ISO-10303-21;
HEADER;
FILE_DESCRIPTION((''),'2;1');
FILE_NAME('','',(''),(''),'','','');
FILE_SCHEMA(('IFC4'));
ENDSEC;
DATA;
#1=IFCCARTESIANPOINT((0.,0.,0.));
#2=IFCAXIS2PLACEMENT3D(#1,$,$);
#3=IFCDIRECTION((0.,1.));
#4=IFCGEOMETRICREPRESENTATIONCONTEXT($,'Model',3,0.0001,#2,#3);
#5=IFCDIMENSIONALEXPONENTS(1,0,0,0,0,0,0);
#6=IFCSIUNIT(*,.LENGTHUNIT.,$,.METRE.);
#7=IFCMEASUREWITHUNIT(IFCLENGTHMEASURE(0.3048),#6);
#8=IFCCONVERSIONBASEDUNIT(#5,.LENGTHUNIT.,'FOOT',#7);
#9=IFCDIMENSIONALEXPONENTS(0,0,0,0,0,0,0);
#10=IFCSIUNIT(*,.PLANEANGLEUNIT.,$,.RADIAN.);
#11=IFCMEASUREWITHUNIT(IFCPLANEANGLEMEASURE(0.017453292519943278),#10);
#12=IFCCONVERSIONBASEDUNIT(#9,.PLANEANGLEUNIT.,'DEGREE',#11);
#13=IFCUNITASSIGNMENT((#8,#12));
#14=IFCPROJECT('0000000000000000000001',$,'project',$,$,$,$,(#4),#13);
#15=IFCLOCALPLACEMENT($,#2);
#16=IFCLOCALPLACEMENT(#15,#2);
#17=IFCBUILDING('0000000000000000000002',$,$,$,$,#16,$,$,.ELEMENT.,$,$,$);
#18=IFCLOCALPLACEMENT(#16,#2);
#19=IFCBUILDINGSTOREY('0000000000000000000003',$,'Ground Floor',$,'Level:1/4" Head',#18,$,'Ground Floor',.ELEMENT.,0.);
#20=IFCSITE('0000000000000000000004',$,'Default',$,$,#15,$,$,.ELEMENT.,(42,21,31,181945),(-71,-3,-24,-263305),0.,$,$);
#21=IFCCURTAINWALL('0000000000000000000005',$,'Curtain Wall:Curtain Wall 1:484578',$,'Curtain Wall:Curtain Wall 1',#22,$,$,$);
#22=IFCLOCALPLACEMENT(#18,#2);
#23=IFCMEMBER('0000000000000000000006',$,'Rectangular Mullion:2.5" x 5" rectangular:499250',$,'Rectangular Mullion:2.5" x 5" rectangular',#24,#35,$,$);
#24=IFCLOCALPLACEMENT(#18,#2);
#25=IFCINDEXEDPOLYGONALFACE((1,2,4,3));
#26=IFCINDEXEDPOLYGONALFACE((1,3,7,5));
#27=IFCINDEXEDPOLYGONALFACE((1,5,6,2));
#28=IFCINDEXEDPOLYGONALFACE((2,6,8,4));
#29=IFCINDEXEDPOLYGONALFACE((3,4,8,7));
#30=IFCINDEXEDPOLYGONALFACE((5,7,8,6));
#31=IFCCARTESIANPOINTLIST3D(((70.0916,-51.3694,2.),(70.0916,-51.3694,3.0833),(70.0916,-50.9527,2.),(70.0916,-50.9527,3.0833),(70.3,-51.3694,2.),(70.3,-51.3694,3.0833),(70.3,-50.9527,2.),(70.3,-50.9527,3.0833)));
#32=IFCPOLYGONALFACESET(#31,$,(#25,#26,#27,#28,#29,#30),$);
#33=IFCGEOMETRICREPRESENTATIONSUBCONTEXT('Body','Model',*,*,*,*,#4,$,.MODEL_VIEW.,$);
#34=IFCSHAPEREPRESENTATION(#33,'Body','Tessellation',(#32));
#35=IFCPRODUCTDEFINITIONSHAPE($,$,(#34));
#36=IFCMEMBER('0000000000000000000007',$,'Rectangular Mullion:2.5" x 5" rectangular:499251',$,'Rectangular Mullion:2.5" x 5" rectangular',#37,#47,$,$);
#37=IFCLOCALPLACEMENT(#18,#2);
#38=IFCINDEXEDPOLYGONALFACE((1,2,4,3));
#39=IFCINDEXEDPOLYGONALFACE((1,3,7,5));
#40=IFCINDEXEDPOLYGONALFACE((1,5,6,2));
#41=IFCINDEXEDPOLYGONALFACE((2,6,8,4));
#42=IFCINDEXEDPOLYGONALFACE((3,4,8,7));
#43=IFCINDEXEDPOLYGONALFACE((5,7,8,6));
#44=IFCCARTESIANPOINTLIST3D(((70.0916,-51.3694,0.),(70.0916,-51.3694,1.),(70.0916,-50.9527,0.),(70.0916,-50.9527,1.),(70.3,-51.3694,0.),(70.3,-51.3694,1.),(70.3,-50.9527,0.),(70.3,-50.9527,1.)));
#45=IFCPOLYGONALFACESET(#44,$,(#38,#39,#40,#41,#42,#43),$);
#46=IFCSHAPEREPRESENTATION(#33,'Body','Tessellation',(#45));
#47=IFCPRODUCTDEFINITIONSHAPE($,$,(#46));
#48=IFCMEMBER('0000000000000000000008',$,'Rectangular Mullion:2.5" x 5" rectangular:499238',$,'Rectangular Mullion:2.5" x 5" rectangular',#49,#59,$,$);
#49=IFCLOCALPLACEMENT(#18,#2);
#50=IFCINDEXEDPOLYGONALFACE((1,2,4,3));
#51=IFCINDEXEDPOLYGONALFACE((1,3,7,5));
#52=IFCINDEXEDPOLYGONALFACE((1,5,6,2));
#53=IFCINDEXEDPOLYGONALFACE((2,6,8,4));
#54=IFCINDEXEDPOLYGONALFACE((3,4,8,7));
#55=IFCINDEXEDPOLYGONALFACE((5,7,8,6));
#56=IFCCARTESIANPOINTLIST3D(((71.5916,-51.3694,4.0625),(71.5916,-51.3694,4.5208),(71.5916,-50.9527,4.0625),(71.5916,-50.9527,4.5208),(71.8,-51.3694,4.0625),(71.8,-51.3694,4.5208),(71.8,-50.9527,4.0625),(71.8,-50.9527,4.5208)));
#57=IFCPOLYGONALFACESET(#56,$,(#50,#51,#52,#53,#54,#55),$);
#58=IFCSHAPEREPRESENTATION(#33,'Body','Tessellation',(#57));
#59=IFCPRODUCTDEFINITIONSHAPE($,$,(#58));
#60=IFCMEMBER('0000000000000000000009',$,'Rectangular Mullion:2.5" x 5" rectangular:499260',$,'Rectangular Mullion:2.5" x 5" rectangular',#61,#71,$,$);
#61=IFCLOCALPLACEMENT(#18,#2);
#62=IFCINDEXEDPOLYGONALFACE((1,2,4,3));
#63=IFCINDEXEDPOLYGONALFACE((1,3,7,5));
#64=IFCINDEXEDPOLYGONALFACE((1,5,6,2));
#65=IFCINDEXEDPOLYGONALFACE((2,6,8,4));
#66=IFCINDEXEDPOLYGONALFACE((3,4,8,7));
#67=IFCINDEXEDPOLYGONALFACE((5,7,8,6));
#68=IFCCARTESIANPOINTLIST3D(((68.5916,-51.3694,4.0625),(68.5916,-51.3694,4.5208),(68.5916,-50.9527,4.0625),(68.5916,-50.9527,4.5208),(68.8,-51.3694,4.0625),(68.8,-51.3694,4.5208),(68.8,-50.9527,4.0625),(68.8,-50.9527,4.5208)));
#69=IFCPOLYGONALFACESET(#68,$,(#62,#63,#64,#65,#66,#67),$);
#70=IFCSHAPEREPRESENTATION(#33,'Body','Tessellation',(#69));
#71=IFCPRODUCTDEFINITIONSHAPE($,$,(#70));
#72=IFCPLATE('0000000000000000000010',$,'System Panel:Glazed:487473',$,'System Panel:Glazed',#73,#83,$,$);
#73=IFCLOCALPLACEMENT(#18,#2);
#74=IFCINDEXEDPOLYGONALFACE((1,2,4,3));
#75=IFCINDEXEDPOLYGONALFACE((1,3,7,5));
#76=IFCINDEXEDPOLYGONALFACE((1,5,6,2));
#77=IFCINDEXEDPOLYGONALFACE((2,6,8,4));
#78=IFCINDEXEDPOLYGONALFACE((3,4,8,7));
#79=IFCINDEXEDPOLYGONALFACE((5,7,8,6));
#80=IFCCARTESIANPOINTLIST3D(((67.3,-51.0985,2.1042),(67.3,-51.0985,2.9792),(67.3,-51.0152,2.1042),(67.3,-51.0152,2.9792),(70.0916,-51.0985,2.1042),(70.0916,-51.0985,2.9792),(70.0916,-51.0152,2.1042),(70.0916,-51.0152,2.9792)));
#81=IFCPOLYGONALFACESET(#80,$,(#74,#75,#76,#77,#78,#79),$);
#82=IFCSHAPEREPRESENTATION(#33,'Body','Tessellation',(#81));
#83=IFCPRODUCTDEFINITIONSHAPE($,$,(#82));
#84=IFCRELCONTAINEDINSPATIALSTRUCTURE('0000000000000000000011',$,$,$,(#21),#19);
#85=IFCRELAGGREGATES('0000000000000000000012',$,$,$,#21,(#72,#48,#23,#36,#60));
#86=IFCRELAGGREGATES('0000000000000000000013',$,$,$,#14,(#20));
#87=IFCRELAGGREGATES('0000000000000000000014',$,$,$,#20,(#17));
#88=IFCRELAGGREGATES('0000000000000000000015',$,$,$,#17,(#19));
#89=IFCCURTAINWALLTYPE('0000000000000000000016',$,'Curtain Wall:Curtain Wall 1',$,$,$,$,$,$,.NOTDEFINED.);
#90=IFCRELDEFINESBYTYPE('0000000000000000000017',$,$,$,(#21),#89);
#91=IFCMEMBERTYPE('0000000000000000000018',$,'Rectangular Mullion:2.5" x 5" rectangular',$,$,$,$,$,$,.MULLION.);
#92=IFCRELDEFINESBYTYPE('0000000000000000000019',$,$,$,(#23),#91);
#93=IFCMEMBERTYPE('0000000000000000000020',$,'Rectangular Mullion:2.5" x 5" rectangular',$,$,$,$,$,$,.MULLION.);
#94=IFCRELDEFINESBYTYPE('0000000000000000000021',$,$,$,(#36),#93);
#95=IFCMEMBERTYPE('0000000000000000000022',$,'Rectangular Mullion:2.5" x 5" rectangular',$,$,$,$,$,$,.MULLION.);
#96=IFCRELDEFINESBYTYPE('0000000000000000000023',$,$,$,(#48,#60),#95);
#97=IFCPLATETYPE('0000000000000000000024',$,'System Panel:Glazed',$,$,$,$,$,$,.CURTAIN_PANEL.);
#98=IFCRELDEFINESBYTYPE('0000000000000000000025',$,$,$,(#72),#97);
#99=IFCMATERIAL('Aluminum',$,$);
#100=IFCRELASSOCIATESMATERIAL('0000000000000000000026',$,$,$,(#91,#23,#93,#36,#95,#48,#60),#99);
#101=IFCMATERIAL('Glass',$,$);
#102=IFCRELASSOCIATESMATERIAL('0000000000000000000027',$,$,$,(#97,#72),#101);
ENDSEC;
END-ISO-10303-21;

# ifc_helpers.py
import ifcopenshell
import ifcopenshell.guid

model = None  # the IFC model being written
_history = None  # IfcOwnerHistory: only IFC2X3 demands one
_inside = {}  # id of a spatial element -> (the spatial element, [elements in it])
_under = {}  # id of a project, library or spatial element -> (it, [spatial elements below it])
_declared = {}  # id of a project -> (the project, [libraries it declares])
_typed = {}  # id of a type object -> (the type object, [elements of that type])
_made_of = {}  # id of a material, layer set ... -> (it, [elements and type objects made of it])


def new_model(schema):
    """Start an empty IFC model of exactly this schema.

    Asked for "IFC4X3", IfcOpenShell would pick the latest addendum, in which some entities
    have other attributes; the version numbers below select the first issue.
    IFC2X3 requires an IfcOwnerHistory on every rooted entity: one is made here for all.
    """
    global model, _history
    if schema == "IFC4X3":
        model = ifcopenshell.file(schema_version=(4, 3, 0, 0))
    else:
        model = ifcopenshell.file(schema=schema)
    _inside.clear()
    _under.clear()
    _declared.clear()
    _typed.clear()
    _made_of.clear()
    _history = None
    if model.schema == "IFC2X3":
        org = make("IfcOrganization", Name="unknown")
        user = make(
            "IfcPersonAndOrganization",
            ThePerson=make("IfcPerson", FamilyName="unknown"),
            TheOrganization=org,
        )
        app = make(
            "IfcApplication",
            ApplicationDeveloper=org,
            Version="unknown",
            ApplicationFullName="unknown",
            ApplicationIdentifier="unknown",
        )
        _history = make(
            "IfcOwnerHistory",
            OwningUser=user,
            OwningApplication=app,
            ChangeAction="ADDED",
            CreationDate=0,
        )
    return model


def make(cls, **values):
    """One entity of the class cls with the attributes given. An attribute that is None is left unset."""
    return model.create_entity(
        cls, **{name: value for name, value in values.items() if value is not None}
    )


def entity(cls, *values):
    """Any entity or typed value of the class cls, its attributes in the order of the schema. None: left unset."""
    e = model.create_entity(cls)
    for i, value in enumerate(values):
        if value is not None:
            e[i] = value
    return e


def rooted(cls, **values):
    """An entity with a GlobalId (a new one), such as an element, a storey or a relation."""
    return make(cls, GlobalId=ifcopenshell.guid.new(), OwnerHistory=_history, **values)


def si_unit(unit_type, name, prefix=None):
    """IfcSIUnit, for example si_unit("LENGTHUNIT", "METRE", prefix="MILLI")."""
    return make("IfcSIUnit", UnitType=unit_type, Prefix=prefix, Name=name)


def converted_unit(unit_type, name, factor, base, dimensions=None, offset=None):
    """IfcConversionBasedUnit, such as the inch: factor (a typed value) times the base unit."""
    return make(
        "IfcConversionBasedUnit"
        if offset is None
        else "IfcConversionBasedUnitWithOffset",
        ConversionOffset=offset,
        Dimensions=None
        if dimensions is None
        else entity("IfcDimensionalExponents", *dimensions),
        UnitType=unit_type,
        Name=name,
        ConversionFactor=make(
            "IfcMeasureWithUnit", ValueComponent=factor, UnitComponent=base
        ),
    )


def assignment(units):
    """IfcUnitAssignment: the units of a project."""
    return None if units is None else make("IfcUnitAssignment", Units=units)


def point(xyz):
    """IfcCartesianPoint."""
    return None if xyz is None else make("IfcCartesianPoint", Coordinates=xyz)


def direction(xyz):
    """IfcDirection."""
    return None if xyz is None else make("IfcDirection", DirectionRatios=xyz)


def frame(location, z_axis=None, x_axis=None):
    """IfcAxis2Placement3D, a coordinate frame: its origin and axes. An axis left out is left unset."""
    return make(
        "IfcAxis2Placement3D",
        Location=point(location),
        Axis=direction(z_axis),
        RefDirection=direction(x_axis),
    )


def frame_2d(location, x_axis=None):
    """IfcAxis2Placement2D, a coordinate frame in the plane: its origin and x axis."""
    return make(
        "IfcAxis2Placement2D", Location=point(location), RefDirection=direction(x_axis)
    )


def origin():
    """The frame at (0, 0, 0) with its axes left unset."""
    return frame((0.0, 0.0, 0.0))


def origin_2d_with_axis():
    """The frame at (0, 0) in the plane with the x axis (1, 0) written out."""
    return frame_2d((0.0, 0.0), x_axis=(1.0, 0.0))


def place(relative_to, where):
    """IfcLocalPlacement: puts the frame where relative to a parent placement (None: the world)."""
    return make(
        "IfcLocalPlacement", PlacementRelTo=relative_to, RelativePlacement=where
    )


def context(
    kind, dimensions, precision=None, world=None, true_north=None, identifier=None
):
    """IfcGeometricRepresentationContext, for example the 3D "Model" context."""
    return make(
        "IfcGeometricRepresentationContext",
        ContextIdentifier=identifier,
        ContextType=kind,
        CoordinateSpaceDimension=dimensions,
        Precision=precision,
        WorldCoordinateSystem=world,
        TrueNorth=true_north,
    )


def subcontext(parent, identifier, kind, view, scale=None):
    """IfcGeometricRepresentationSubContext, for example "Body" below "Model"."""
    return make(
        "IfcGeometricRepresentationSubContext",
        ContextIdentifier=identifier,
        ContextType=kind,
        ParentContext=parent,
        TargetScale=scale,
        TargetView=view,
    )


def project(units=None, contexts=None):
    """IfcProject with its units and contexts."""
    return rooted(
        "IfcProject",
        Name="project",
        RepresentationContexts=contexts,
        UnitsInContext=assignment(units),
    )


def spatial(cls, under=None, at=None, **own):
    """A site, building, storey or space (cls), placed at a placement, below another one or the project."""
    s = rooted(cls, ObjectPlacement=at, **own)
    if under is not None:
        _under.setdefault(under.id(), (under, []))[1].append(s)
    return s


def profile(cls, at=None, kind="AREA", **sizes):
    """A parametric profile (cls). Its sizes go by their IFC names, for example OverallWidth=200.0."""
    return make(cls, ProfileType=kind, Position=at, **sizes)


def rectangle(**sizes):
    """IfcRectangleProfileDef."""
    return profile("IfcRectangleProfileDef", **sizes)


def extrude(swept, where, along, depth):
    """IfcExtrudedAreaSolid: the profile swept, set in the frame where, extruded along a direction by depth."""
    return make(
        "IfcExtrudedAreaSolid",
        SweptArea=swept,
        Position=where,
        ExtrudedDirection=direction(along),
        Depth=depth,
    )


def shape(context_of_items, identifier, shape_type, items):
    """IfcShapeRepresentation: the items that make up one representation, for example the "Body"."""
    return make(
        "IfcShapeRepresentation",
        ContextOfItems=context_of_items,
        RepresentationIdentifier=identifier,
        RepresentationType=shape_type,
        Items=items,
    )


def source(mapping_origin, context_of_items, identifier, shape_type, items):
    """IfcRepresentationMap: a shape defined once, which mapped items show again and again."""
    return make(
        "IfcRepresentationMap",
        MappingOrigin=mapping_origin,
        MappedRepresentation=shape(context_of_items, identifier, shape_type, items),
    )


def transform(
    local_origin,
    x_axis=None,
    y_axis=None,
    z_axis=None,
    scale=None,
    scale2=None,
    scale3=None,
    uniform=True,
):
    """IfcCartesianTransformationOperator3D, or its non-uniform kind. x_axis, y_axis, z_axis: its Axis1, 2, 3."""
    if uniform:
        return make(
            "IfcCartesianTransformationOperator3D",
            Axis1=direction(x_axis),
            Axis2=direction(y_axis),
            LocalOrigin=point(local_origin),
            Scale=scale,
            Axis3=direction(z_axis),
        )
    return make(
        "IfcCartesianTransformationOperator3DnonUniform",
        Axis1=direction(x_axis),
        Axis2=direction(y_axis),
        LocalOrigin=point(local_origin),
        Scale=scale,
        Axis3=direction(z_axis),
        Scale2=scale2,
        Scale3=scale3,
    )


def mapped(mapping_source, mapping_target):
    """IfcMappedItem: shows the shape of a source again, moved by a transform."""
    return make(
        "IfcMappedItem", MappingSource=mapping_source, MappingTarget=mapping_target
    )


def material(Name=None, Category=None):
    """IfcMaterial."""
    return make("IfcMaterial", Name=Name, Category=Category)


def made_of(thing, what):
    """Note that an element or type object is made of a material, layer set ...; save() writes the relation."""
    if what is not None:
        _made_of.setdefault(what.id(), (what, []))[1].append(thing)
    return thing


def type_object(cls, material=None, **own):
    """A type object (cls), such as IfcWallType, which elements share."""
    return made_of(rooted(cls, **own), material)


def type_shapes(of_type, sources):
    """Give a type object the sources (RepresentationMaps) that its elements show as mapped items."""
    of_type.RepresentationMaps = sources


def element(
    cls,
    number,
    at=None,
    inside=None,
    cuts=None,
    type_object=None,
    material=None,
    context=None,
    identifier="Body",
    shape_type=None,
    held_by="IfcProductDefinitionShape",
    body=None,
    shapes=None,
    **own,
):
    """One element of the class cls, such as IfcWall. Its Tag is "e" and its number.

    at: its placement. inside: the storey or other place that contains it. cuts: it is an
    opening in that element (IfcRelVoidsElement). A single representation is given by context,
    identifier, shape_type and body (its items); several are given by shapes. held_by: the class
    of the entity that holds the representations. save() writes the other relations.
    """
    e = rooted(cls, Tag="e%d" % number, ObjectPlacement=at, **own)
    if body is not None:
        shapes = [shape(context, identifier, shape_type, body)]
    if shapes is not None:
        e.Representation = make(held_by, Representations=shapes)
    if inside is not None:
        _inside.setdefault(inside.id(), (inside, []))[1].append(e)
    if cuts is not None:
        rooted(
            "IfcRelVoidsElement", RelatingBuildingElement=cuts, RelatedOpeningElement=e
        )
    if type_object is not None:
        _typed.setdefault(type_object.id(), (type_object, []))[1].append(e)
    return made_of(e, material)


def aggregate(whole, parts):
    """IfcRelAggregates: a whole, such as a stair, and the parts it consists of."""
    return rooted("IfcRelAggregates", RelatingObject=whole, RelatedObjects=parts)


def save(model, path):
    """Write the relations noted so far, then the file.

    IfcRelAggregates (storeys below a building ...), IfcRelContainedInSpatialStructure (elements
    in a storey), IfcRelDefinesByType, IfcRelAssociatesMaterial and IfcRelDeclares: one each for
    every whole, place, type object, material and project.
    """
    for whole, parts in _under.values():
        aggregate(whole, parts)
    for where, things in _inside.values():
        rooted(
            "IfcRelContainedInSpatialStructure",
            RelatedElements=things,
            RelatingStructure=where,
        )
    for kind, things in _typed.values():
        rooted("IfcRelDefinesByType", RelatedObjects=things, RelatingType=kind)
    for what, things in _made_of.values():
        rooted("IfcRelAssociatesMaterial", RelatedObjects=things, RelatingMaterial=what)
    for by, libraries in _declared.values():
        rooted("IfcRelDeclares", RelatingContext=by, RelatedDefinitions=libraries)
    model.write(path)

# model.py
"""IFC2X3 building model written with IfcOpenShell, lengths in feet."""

from ifc_helpers import new_model, entity, si_unit, converted_unit, direction, frame, origin, origin_2d_with_axis, place, context, subcontext, project, spatial, rectangle, extrude, source, transform, mapped, material, type_object, type_shapes, element, aggregate, save


model = new_model("IFC2X3")

# Units and contexts
model_context = context("Model", 3, precision=0.0001, world=origin(), true_north=direction((0.0, 1.0)))
body_context = subcontext(model_context, "Body", "Model", "MODEL_VIEW")
ifc_project = project(units=[converted_unit("LENGTHUNIT", "FOOT", entity("IfcLengthMeasure", 0.3048), si_unit("LENGTHUNIT", "METRE"), dimensions=[1, 0, 0, 0, 0, 0, 0]), converted_unit("PLANEANGLEUNIT", "DEGREE", entity("IfcPlaneAngleMeasure", 0.017453292519943278), si_unit("PLANEANGLEUNIT", "RADIAN"), dimensions=[0, 0, 0, 0, 0, 0, 0])], contexts=[model_context])

# Site, building, storey
site_placement = place(None, origin())
site = spatial("IfcSite", under=ifc_project, at=site_placement, Name="Default", CompositionType="ELEMENT", RefLatitude=(42, 21, 31, 181945), RefLongitude=(-71, -3, -24, -263305), RefElevation=0.0)
building_placement = place(site_placement, origin())
building = spatial("IfcBuilding", under=site, at=building_placement, CompositionType="ELEMENT")
storey_placement = place(building_placement, origin())
storey = spatial("IfcBuildingStorey", under=building, at=storey_placement, Name="Ground Floor", ObjectType="Level:1/4\" Head", LongName="Ground Floor", CompositionType="ELEMENT", Elevation=0.0)

# Curtain wall, members, plate
curtain_wall_type = type_object("IfcCurtainWallType", Name="Curtain Wall:Curtain Wall 1", PredefinedType="NOTDEFINED")
curtain_wall_placement = place(storey_placement, origin())
curtain_wall = element("IfcCurtainWall", 1, at=curtain_wall_placement, inside=storey, type_object=curtain_wall_type, Name="Curtain Wall:Curtain Wall 1:484578", ObjectType="Curtain Wall:Curtain Wall 1")
ifc_material_1 = material(Name="Aluminum")
member_type_1 = type_object("IfcMemberType", Name="Rectangular Mullion:2.5\" x 5\" rectangular", PredefinedType="MULLION", material=ifc_material_1)
shared_shape_1 = source(origin(), body_context, "Body", "SweptSolid", [
    extrude(rectangle(XDim=0.2083, YDim=0.4167, at=origin_2d_with_axis()), frame((0.0, 0.0, -1.0833), z_axis=(0.0, 0.0, 1.0), x_axis=(-1.0, 0.0, 0.0)), (0.0, 0.0, 1.0), 1.0833),
])
type_shapes(member_type_1, [shared_shape_1])
member_1_placement = place(curtain_wall_placement, frame((70.1958, -51.161, 2.0), z_axis=(0.0, 0.0, -1.0), x_axis=(1.0, 0.0, 0.0)))
member_1 = element("IfcMember", 2, at=member_1_placement, type_object=member_type_1, material=ifc_material_1, Name="Rectangular Mullion:2.5\" x 5\" rectangular:499250", ObjectType="Rectangular Mullion:2.5\" x 5\" rectangular", context=body_context, shape_type="MappedRepresentation", body=[
    mapped(shared_shape_1, transform((0.0, 0.0, 0.0), scale=1.0)),
])
member_type_2 = type_object("IfcMemberType", Name="Rectangular Mullion:2.5\" x 5\" rectangular", PredefinedType="MULLION", material=ifc_material_1)
shared_shape_2 = source(origin(), body_context, "Body", "SweptSolid", [
    extrude(rectangle(XDim=0.2083, YDim=0.4167, at=origin_2d_with_axis()), frame((0.0, 0.0, -1.0), z_axis=(0.0, 0.0, 1.0), x_axis=(-1.0, 0.0, 0.0)), (0.0, 0.0, 1.0), 1.0),
])
type_shapes(member_type_2, [shared_shape_2])
member_2_placement = place(curtain_wall_placement, frame((70.1958, -51.161, 0.0), z_axis=(0.0, 0.0, -1.0), x_axis=(1.0, 0.0, 0.0)))
member_2 = element("IfcMember", 3, at=member_2_placement, type_object=member_type_2, material=ifc_material_1, Name="Rectangular Mullion:2.5\" x 5\" rectangular:499251", ObjectType="Rectangular Mullion:2.5\" x 5\" rectangular", context=body_context, shape_type="MappedRepresentation", body=[
    mapped(shared_shape_2, transform((0.0, 0.0, 0.0), scale=1.0)),
])
member_type_3 = type_object("IfcMemberType", Name="Rectangular Mullion:2.5\" x 5\" rectangular", PredefinedType="MULLION", material=ifc_material_1)
shared_shape_3 = source(origin(), body_context, "Body", "SweptSolid", [
    extrude(rectangle(XDim=0.2083, YDim=0.4167, at=origin_2d_with_axis()), frame((0.0, 0.0, -0.4583), z_axis=(0.0, 0.0, 1.0), x_axis=(-1.0, 0.0, 0.0)), (0.0, 0.0, 1.0), 0.4583),
])
type_shapes(member_type_3, [shared_shape_3])
member_3_placement = place(curtain_wall_placement, frame((71.6958, -51.161, 4.0625), z_axis=(0.0, 0.0, -1.0), x_axis=(1.0, 0.0, 0.0)))
member_3 = element("IfcMember", 4, at=member_3_placement, type_object=member_type_3, material=ifc_material_1, Name="Rectangular Mullion:2.5\" x 5\" rectangular:499238", ObjectType="Rectangular Mullion:2.5\" x 5\" rectangular", context=body_context, shape_type="MappedRepresentation", body=[
    mapped(shared_shape_3, transform((0.0, 0.0, 0.0), scale=1.0)),
])
member_4_placement = place(curtain_wall_placement, frame((68.6958, -51.161, 4.0625), z_axis=(0.0, 0.0, -1.0), x_axis=(1.0, 0.0, 0.0)))
member_4 = element("IfcMember", 5, at=member_4_placement, type_object=member_type_3, material=ifc_material_1, Name="Rectangular Mullion:2.5\" x 5\" rectangular:499260", ObjectType="Rectangular Mullion:2.5\" x 5\" rectangular", context=body_context, shape_type="MappedRepresentation", body=[
    mapped(shared_shape_3, transform((0.0, 0.0, 0.0), scale=1.0)),
])
ifc_material_2 = material(Name="Glass")
plate_type_1 = type_object("IfcPlateType", Name="System Panel:Glazed", PredefinedType="CURTAIN_PANEL", material=ifc_material_2)
shared_shape_4 = source(origin(), body_context, "Body", "SweptSolid", [
    extrude(rectangle(XDim=0.875, YDim=2.7917, at=origin_2d_with_axis()), frame((0.0, 0.0625, 0.4375), z_axis=(0.0, 1.0, 0.0), x_axis=(0.0, 0.0, 1.0)), (0.0, 0.0, 1.0), 0.0833),
])
type_shapes(plate_type_1, [shared_shape_4])
plate_1_placement = place(curtain_wall_placement, frame((68.6958, -51.161, 2.1042)))
plate_1 = element("IfcPlate", 6, at=plate_1_placement, type_object=plate_type_1, material=ifc_material_2, Name="System Panel:Glazed:487473", ObjectType="System Panel:Glazed", context=body_context, shape_type="MappedRepresentation", body=[
    mapped(shared_shape_4, transform((0.0, 0.0, 0.0), scale=1.0)),
])
aggregate(curtain_wall, [plate_1, member_3, member_1, member_2, member_4])

save(model, "model.ifc")
